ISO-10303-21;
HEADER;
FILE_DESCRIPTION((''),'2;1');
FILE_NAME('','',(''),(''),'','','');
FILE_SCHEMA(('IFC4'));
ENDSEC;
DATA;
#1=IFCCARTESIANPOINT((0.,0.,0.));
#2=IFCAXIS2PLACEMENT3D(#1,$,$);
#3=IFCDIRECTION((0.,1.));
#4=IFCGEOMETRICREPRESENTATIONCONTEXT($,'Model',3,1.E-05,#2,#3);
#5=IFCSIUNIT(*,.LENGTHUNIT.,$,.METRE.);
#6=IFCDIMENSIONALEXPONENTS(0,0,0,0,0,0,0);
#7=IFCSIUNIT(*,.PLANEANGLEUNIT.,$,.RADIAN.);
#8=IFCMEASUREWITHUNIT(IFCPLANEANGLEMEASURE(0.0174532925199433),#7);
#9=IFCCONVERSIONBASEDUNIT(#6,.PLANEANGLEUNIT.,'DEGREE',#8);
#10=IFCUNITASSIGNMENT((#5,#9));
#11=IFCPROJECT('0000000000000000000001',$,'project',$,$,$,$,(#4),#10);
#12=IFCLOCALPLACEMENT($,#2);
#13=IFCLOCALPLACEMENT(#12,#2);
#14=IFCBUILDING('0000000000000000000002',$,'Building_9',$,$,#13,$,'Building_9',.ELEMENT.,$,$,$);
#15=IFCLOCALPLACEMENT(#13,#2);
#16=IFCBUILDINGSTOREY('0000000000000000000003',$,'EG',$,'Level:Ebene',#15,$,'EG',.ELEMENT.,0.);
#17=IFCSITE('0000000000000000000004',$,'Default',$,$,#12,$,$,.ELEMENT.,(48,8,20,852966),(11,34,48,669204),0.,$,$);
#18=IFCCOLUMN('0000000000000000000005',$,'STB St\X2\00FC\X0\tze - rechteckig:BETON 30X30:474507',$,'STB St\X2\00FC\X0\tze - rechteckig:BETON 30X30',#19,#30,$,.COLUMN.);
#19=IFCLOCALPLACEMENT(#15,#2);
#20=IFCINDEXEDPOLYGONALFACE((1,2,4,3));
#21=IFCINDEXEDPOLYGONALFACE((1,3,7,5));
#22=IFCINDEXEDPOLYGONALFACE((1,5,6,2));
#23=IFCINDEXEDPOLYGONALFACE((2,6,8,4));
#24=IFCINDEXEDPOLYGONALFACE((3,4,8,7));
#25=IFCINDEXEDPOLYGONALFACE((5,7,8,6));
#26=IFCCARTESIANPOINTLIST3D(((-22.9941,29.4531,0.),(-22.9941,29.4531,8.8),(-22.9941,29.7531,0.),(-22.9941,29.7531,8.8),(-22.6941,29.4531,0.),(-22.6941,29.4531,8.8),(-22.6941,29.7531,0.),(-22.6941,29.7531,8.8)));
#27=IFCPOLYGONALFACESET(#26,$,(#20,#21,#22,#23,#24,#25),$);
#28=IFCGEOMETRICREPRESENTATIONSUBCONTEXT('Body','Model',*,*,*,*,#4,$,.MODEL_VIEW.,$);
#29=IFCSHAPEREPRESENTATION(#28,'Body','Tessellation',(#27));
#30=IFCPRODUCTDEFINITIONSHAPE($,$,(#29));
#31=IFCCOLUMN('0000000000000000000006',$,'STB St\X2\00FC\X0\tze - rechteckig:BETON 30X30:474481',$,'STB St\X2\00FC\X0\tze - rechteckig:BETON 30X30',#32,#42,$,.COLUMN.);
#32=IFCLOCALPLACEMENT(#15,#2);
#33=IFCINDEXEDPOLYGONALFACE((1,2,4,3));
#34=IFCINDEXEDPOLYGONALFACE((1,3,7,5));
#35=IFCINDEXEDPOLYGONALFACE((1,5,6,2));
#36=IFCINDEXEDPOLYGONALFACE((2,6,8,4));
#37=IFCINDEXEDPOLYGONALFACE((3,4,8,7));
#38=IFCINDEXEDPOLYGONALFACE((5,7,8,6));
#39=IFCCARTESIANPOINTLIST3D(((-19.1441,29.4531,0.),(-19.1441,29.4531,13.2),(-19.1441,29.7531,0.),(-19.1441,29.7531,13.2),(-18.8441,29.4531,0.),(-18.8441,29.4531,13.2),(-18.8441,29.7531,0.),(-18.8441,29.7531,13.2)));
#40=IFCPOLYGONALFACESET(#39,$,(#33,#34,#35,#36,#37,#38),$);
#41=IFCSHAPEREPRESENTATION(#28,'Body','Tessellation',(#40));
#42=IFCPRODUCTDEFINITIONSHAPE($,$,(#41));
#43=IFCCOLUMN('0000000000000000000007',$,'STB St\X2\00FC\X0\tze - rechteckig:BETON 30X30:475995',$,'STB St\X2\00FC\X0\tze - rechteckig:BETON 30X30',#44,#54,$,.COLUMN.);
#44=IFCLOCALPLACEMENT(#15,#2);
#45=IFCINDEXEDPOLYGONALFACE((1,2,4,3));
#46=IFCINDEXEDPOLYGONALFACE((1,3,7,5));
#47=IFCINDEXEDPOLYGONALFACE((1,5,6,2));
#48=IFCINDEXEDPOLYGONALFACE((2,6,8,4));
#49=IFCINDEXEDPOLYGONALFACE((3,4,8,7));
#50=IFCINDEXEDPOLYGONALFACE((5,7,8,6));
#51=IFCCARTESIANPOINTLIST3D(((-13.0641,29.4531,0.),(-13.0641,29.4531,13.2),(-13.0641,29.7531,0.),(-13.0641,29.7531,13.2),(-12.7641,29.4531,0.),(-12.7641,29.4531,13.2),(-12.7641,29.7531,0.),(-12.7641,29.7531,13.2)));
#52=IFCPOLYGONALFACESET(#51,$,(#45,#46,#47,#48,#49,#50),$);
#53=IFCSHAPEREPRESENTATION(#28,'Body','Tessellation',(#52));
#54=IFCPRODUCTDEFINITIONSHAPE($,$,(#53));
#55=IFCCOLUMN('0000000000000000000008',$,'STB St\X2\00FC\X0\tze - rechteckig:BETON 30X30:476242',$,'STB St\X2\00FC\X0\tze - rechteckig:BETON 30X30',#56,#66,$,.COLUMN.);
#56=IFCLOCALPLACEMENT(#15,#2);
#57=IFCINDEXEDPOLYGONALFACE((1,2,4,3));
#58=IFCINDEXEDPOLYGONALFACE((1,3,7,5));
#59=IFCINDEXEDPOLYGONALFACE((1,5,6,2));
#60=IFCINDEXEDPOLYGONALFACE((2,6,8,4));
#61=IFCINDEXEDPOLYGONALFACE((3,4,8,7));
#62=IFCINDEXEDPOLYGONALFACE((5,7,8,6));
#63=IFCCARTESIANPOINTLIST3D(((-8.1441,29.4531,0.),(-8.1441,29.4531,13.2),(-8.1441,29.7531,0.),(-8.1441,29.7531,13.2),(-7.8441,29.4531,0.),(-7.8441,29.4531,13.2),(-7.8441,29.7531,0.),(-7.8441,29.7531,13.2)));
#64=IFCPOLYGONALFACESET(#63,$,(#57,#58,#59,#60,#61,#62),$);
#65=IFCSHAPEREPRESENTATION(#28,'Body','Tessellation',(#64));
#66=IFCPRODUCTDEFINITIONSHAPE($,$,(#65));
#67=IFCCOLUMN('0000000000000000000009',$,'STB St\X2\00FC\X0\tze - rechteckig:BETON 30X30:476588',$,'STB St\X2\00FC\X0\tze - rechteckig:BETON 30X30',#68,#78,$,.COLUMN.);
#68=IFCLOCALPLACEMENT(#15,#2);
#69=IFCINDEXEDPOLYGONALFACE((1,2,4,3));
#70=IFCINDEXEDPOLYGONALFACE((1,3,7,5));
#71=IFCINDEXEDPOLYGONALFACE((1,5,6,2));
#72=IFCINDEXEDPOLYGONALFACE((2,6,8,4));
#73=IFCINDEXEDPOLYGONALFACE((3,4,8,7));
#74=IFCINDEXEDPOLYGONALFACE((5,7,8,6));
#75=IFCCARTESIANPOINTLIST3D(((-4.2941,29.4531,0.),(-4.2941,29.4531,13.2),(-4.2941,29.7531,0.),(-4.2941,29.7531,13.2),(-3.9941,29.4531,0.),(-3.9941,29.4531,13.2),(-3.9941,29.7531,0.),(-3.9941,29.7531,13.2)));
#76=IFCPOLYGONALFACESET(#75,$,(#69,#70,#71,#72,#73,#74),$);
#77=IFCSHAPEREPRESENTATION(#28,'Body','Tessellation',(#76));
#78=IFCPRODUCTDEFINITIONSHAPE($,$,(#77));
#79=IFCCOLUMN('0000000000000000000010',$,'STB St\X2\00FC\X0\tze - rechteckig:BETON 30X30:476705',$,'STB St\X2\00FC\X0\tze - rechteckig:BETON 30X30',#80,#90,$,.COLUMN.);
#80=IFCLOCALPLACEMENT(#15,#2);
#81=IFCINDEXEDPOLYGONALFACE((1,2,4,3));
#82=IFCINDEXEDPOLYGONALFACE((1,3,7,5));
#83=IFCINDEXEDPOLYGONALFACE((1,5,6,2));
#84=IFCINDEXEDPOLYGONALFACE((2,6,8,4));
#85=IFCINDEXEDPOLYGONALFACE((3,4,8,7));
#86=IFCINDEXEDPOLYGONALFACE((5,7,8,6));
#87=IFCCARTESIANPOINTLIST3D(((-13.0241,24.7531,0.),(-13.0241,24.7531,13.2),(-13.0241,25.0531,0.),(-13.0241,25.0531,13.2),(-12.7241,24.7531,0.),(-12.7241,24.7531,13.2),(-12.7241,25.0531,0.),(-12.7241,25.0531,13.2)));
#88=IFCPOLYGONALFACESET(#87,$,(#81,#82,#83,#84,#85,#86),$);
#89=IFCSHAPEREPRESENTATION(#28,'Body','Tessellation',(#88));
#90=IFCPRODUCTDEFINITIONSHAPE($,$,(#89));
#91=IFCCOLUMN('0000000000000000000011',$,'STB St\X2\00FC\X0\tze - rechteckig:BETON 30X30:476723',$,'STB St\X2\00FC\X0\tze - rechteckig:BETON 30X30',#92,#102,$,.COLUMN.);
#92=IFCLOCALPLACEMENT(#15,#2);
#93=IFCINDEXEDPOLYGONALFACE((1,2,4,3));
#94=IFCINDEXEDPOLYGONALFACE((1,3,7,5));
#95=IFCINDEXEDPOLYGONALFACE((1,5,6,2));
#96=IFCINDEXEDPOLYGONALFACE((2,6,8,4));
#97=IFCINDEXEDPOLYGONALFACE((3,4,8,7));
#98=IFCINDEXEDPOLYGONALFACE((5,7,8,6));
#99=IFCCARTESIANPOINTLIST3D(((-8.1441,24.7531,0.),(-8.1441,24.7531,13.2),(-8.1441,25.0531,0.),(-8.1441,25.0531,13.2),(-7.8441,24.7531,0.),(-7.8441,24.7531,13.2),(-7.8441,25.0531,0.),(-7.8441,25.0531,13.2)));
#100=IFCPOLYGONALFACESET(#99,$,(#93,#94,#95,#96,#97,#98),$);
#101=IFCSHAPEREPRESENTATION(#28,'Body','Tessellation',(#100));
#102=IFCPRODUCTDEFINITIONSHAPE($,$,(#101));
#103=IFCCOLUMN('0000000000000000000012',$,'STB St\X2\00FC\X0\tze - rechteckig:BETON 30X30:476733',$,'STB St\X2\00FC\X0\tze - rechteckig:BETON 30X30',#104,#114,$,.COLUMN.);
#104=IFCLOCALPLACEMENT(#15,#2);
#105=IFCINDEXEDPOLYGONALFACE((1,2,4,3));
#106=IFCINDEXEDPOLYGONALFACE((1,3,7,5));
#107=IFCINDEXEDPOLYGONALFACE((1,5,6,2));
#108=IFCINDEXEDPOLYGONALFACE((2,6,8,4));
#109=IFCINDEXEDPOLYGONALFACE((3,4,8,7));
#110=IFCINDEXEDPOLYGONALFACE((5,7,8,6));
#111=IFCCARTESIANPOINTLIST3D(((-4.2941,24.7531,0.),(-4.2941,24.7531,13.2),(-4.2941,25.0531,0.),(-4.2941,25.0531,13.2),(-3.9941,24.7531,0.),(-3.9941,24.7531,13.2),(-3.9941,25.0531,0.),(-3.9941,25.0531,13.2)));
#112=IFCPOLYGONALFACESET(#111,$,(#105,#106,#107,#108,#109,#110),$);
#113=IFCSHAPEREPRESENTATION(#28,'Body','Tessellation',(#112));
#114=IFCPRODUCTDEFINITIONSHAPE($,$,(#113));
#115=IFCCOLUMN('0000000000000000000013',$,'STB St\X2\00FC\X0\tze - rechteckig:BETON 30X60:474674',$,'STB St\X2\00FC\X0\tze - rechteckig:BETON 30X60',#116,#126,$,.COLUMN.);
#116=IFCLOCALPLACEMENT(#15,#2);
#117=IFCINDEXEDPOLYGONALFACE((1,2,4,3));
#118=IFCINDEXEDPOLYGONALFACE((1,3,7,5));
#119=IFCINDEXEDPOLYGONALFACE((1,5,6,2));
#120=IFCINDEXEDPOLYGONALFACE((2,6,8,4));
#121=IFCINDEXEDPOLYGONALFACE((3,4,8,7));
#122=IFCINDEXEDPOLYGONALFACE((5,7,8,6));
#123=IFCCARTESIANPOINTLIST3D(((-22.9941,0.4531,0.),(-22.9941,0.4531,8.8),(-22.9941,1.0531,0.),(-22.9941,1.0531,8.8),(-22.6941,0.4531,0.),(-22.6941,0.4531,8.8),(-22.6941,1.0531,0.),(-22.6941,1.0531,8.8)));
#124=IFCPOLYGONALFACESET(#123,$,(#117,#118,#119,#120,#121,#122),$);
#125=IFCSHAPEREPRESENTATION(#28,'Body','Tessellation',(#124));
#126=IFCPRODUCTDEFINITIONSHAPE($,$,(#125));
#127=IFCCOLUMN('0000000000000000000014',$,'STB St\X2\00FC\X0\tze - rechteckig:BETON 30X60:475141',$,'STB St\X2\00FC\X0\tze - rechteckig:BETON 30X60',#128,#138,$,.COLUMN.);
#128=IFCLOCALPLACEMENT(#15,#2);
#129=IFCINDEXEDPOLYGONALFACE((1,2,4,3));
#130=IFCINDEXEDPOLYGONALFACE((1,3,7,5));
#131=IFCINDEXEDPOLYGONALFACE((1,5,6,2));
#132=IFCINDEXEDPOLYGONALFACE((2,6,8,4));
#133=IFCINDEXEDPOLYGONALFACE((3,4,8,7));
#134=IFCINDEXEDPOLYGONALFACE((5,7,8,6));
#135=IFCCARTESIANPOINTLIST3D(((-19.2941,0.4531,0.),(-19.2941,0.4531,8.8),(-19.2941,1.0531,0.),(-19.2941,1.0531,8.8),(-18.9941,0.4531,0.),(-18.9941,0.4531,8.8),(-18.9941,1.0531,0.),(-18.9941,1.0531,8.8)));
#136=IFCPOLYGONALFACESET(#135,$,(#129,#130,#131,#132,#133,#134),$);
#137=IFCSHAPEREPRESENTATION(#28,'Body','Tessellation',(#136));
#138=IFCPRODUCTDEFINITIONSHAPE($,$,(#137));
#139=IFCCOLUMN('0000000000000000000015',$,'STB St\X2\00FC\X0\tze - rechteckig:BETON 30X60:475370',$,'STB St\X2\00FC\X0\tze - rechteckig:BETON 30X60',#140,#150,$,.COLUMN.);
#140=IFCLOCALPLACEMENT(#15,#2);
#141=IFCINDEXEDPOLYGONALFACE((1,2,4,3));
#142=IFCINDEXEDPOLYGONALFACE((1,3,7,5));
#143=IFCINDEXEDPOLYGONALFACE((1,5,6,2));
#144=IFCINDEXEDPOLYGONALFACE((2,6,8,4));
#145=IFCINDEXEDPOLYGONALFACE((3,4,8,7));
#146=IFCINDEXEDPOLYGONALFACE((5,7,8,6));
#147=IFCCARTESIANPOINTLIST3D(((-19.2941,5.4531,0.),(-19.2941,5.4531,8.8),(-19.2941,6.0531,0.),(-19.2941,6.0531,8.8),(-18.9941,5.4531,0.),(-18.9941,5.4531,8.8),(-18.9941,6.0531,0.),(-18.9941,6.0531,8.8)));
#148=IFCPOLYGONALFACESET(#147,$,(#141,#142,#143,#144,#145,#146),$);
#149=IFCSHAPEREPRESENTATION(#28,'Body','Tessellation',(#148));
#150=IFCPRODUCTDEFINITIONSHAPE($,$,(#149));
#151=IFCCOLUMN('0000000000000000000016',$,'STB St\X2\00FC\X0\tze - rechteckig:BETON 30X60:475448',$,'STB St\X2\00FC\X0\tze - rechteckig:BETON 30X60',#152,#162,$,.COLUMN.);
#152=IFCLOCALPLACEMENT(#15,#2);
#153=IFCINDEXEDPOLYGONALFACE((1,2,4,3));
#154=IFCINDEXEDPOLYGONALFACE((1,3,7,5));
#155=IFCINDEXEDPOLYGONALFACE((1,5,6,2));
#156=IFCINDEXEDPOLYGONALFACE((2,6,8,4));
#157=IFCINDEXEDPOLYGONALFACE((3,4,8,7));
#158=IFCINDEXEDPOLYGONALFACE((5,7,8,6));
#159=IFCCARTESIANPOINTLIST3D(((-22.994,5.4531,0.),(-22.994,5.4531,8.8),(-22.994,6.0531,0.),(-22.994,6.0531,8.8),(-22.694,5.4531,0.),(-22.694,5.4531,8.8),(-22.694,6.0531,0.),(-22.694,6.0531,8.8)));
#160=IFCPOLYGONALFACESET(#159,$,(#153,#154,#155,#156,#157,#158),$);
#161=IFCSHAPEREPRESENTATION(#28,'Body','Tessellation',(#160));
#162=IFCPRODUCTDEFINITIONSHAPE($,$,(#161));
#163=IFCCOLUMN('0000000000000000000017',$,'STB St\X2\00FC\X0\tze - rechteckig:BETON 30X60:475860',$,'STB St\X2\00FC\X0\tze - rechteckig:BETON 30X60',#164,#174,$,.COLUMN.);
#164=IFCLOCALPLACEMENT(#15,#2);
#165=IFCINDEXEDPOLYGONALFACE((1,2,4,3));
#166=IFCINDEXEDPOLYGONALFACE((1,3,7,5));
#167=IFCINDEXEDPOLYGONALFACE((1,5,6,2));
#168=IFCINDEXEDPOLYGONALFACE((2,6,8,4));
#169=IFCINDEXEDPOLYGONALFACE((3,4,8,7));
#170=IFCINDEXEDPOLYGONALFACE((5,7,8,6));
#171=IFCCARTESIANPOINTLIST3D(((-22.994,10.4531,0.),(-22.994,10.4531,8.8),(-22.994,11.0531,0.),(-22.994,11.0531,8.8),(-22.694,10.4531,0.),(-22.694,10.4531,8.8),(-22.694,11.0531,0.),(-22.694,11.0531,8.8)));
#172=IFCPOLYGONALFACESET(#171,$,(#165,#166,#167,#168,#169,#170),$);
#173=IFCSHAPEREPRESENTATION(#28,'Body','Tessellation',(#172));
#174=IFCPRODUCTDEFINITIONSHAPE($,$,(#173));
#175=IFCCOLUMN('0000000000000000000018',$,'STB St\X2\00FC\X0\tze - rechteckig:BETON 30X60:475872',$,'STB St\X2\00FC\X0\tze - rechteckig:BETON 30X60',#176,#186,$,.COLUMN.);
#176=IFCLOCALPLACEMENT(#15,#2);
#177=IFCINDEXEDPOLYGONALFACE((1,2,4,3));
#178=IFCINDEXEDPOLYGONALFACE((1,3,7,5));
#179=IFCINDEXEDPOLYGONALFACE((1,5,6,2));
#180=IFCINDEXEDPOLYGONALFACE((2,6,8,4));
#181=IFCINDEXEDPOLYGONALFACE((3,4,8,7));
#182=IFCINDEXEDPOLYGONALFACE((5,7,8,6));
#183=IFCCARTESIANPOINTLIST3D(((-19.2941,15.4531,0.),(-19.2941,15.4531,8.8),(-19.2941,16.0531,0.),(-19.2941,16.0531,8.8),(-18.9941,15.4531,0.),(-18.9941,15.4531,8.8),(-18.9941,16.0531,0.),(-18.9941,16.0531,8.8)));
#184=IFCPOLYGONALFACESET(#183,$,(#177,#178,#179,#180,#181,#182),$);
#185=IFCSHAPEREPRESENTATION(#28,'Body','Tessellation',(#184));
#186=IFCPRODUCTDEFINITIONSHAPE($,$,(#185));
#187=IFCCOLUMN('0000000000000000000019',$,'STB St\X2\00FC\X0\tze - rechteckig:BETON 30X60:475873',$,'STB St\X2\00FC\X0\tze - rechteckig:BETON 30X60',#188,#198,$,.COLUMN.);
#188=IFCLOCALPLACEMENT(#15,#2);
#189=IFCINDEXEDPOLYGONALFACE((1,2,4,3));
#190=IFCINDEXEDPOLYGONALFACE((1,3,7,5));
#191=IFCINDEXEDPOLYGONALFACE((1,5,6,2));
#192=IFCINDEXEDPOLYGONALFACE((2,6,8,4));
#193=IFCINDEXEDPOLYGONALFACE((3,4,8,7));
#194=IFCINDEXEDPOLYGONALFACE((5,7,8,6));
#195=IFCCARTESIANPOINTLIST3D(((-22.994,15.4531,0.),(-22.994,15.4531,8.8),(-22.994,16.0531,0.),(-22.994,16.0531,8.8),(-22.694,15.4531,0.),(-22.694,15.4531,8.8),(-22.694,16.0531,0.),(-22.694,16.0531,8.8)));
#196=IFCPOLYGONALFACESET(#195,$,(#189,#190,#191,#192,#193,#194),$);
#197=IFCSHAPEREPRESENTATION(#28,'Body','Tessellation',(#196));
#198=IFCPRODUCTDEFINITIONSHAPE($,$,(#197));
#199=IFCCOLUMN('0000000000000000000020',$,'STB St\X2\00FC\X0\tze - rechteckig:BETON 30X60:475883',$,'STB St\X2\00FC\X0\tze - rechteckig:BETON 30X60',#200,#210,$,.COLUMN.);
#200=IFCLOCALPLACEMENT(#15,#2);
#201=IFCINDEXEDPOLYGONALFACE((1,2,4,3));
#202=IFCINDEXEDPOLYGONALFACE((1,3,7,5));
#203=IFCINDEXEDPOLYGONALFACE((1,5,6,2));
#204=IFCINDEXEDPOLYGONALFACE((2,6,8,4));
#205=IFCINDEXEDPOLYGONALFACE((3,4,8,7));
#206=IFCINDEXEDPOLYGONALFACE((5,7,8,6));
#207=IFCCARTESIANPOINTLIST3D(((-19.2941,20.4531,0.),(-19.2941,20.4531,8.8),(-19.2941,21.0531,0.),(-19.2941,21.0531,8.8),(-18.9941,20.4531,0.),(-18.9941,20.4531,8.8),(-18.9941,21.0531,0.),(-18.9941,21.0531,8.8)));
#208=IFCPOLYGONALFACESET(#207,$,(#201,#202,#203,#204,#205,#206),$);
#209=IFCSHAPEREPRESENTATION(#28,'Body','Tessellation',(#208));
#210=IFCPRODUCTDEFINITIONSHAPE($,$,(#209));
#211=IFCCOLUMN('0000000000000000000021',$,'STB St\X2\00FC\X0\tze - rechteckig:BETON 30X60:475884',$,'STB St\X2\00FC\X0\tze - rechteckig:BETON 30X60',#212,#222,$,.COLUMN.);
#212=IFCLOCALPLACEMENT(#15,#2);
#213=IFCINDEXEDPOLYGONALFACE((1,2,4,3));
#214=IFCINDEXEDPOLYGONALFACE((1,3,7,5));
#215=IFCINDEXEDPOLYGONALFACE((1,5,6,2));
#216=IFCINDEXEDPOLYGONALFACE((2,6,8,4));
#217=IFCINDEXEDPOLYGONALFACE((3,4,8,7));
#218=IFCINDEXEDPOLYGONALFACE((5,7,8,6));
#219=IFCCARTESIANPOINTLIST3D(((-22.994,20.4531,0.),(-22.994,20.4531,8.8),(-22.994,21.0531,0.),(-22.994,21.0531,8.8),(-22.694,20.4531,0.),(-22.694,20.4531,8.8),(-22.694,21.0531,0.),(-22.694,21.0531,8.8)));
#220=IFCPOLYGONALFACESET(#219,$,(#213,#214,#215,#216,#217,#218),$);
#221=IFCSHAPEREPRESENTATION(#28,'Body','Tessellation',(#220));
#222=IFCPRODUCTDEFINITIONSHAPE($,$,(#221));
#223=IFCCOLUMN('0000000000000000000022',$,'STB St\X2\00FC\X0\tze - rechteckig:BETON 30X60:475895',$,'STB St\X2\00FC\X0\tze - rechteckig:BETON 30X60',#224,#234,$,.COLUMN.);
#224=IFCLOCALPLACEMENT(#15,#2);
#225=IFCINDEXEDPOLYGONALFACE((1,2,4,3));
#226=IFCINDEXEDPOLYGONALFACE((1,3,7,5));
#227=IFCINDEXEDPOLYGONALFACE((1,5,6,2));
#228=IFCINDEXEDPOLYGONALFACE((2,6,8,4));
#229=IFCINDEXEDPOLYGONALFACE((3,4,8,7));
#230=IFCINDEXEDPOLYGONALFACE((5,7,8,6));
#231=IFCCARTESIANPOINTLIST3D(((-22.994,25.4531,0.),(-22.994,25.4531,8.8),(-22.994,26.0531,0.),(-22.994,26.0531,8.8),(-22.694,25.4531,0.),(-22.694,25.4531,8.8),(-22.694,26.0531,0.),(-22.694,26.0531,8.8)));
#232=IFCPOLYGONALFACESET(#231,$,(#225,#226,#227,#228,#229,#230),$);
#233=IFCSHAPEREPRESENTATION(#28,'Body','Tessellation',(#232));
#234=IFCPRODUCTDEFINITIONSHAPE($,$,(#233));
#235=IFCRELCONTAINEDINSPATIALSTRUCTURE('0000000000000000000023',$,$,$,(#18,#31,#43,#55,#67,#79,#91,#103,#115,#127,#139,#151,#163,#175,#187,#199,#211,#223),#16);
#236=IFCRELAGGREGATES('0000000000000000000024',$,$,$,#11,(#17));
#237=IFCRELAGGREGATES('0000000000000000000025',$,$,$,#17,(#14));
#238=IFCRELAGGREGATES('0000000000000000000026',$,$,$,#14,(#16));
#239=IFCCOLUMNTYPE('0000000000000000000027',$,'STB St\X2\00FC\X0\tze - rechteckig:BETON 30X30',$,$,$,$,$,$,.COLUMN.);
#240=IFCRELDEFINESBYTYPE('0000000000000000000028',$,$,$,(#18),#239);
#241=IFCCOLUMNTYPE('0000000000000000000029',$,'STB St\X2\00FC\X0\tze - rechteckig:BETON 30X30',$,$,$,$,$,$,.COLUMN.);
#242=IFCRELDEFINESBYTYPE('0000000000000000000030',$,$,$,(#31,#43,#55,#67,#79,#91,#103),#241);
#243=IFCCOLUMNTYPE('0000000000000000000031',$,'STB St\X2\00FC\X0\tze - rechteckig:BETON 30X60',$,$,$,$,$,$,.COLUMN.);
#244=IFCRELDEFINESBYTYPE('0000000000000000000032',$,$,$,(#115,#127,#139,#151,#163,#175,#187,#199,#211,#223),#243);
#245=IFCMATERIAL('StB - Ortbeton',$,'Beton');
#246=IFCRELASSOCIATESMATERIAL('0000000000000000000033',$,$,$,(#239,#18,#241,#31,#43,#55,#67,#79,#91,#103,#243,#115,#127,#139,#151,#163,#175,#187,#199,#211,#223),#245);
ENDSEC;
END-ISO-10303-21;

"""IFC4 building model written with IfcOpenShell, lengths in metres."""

from ifc_helpers import new_model, entity, si_unit, converted_unit, direction, frame, origin, place, context, subcontext, project, spatial, indexed_curve, outline, extrude, source, transform, mapped, material, type_object, type_shapes, element, save


model = new_model("IFC4")

# Units and contexts
model_context = context("Model", 3, precision=1e-05, world=origin(), true_north=direction((0.0, 1.0)))
body_context = subcontext(model_context, "Body", "Model", "MODEL_VIEW")
ifc_project = project(units=[si_unit("LENGTHUNIT", "METRE"), converted_unit("PLANEANGLEUNIT", "DEGREE", entity("IfcPlaneAngleMeasure", 0.0174532925199433), si_unit("PLANEANGLEUNIT", "RADIAN"), dimensions=[0, 0, 0, 0, 0, 0, 0])], contexts=[model_context])

# Site, building, storey
site_placement = place(None, origin())
site = spatial("IfcSite", under=ifc_project, at=site_placement, Name="Default", CompositionType="ELEMENT", RefLatitude=(48, 8, 20, 852966), RefLongitude=(11, 34, 48, 669204), RefElevation=0.0)
building_placement = place(site_placement, origin())
building = spatial("IfcBuilding", under=site, at=building_placement, Name="Building_9", LongName="Building_9", CompositionType="ELEMENT")
storey_placement = place(building_placement, origin())
storey = spatial("IfcBuildingStorey", under=building, at=storey_placement, Name="EG", ObjectType="Level:Ebene", LongName="EG", CompositionType="ELEMENT", Elevation=0.0)

# Columns
ifc_material_1 = material(Name="StB - Ortbeton", Category="Beton")
column_type_1 = type_object("IfcColumnType", Name="STB Stütze - rechteckig:BETON 30X30", PredefinedType="COLUMN", material=ifc_material_1)
shared_shape_1 = source(origin(), body_context, "Body", "SweptSolid", [
    extrude(outline(indexed_curve([(-0.15, -0.15), (0.15, -0.15), (0.15, 0.15), (-0.15, 0.15), (-0.15, -0.15)], self_intersect=False)), frame((0.0, 0.0, 0.0), z_axis=(0.0, 0.0, 1.0), x_axis=(-1.0, 0.0, 0.0)), (0.0, 0.0, 1.0), 8.8),
])
type_shapes(column_type_1, [shared_shape_1])
column_1_placement = place(storey_placement, frame((-22.8441, 29.6031, 0.0)))
element("IfcColumn", 1, at=column_1_placement, inside=storey, type_object=column_type_1, material=ifc_material_1, Name="STB Stütze - rechteckig:BETON 30X30:474507", ObjectType="STB Stütze - rechteckig:BETON 30X30", PredefinedType="COLUMN", context=body_context, shape_type="MappedRepresentation", body=[
    mapped(shared_shape_1, transform((0.0, 0.0, 0.0), scale=1.0)),
])
column_type_2 = type_object("IfcColumnType", Name="STB Stütze - rechteckig:BETON 30X30", PredefinedType="COLUMN", material=ifc_material_1)
shared_shape_2 = source(origin(), body_context, "Body", "SweptSolid", [
    extrude(outline(indexed_curve([(-0.15, -0.15), (0.15, -0.15), (0.15, 0.15), (-0.15, 0.15), (-0.15, -0.15)], self_intersect=False)), frame((0.0, 0.0, 0.0), z_axis=(0.0, 0.0, 1.0), x_axis=(-1.0, 0.0, 0.0)), (0.0, 0.0, 1.0), 13.2),
])
type_shapes(column_type_2, [shared_shape_2])
for number, where, name in (
    (2, (-18.9941, 29.6031, 0.0), "STB Stütze - rechteckig:BETON 30X30:474481"),
    (3, (-12.9141, 29.6031, 0.0), "STB Stütze - rechteckig:BETON 30X30:475995"),
    (4, (-7.9941, 29.6031, 0.0), "STB Stütze - rechteckig:BETON 30X30:476242"),
    (5, (-4.1441, 29.6031, 0.0), "STB Stütze - rechteckig:BETON 30X30:476588"),
    (6, (-12.8741, 24.9031, 0.0), "STB Stütze - rechteckig:BETON 30X30:476705"),
    (7, (-7.9941, 24.9031, 0.0), "STB Stütze - rechteckig:BETON 30X30:476723"),
    (8, (-4.1441, 24.9031, 0.0), "STB Stütze - rechteckig:BETON 30X30:476733"),
):
    element("IfcColumn", number, at=place(storey_placement, frame(where)), inside=storey, type_object=column_type_2, material=ifc_material_1, Name=name, ObjectType="STB Stütze - rechteckig:BETON 30X30", PredefinedType="COLUMN", context=body_context, shape_type="MappedRepresentation", body=[
        mapped(shared_shape_2, transform((0.0, 0.0, 0.0), scale=1.0)),
    ])
column_type_3 = type_object("IfcColumnType", Name="STB Stütze - rechteckig:BETON 30X60", PredefinedType="COLUMN", material=ifc_material_1)
shared_shape_3 = source(origin(), body_context, "Body", "SweptSolid", [
    extrude(outline(indexed_curve([(-0.15, -0.3), (0.15, -0.3), (0.15, 0.3), (-0.15, 0.3), (-0.15, -0.3)], self_intersect=False)), frame((0.0, 0.0, 0.0), z_axis=(0.0, 0.0, 1.0), x_axis=(-1.0, 0.0, 0.0)), (0.0, 0.0, 1.0), 8.8),
])
type_shapes(column_type_3, [shared_shape_3])
for number, where, name in (
    (9, (-22.8441, 0.7531, 0.0), "STB Stütze - rechteckig:BETON 30X60:474674"),
    (10, (-19.1441, 0.7531, 0.0), "STB Stütze - rechteckig:BETON 30X60:475141"),
    (11, (-19.1441, 5.7531, 0.0), "STB Stütze - rechteckig:BETON 30X60:475370"),
    (12, (-22.844, 5.7531, 0.0), "STB Stütze - rechteckig:BETON 30X60:475448"),
    (13, (-22.844, 10.7531, 0.0), "STB Stütze - rechteckig:BETON 30X60:475860"),
    (14, (-19.1441, 15.7531, 0.0), "STB Stütze - rechteckig:BETON 30X60:475872"),
    (15, (-22.844, 15.7531, 0.0), "STB Stütze - rechteckig:BETON 30X60:475873"),
    (16, (-19.1441, 20.7531, 0.0), "STB Stütze - rechteckig:BETON 30X60:475883"),
    (17, (-22.844, 20.7531, 0.0), "STB Stütze - rechteckig:BETON 30X60:475884"),
    (18, (-22.844, 25.7531, 0.0), "STB Stütze - rechteckig:BETON 30X60:475895"),
):
    element("IfcColumn", number, at=place(storey_placement, frame(where)), inside=storey, type_object=column_type_3, material=ifc_material_1, Name=name, ObjectType="STB Stütze - rechteckig:BETON 30X60", PredefinedType="COLUMN", context=body_context, shape_type="MappedRepresentation", body=[
        mapped(shared_shape_3, transform((0.0, 0.0, 0.0), scale=1.0)),
    ])

save(model, "model.ifc")
